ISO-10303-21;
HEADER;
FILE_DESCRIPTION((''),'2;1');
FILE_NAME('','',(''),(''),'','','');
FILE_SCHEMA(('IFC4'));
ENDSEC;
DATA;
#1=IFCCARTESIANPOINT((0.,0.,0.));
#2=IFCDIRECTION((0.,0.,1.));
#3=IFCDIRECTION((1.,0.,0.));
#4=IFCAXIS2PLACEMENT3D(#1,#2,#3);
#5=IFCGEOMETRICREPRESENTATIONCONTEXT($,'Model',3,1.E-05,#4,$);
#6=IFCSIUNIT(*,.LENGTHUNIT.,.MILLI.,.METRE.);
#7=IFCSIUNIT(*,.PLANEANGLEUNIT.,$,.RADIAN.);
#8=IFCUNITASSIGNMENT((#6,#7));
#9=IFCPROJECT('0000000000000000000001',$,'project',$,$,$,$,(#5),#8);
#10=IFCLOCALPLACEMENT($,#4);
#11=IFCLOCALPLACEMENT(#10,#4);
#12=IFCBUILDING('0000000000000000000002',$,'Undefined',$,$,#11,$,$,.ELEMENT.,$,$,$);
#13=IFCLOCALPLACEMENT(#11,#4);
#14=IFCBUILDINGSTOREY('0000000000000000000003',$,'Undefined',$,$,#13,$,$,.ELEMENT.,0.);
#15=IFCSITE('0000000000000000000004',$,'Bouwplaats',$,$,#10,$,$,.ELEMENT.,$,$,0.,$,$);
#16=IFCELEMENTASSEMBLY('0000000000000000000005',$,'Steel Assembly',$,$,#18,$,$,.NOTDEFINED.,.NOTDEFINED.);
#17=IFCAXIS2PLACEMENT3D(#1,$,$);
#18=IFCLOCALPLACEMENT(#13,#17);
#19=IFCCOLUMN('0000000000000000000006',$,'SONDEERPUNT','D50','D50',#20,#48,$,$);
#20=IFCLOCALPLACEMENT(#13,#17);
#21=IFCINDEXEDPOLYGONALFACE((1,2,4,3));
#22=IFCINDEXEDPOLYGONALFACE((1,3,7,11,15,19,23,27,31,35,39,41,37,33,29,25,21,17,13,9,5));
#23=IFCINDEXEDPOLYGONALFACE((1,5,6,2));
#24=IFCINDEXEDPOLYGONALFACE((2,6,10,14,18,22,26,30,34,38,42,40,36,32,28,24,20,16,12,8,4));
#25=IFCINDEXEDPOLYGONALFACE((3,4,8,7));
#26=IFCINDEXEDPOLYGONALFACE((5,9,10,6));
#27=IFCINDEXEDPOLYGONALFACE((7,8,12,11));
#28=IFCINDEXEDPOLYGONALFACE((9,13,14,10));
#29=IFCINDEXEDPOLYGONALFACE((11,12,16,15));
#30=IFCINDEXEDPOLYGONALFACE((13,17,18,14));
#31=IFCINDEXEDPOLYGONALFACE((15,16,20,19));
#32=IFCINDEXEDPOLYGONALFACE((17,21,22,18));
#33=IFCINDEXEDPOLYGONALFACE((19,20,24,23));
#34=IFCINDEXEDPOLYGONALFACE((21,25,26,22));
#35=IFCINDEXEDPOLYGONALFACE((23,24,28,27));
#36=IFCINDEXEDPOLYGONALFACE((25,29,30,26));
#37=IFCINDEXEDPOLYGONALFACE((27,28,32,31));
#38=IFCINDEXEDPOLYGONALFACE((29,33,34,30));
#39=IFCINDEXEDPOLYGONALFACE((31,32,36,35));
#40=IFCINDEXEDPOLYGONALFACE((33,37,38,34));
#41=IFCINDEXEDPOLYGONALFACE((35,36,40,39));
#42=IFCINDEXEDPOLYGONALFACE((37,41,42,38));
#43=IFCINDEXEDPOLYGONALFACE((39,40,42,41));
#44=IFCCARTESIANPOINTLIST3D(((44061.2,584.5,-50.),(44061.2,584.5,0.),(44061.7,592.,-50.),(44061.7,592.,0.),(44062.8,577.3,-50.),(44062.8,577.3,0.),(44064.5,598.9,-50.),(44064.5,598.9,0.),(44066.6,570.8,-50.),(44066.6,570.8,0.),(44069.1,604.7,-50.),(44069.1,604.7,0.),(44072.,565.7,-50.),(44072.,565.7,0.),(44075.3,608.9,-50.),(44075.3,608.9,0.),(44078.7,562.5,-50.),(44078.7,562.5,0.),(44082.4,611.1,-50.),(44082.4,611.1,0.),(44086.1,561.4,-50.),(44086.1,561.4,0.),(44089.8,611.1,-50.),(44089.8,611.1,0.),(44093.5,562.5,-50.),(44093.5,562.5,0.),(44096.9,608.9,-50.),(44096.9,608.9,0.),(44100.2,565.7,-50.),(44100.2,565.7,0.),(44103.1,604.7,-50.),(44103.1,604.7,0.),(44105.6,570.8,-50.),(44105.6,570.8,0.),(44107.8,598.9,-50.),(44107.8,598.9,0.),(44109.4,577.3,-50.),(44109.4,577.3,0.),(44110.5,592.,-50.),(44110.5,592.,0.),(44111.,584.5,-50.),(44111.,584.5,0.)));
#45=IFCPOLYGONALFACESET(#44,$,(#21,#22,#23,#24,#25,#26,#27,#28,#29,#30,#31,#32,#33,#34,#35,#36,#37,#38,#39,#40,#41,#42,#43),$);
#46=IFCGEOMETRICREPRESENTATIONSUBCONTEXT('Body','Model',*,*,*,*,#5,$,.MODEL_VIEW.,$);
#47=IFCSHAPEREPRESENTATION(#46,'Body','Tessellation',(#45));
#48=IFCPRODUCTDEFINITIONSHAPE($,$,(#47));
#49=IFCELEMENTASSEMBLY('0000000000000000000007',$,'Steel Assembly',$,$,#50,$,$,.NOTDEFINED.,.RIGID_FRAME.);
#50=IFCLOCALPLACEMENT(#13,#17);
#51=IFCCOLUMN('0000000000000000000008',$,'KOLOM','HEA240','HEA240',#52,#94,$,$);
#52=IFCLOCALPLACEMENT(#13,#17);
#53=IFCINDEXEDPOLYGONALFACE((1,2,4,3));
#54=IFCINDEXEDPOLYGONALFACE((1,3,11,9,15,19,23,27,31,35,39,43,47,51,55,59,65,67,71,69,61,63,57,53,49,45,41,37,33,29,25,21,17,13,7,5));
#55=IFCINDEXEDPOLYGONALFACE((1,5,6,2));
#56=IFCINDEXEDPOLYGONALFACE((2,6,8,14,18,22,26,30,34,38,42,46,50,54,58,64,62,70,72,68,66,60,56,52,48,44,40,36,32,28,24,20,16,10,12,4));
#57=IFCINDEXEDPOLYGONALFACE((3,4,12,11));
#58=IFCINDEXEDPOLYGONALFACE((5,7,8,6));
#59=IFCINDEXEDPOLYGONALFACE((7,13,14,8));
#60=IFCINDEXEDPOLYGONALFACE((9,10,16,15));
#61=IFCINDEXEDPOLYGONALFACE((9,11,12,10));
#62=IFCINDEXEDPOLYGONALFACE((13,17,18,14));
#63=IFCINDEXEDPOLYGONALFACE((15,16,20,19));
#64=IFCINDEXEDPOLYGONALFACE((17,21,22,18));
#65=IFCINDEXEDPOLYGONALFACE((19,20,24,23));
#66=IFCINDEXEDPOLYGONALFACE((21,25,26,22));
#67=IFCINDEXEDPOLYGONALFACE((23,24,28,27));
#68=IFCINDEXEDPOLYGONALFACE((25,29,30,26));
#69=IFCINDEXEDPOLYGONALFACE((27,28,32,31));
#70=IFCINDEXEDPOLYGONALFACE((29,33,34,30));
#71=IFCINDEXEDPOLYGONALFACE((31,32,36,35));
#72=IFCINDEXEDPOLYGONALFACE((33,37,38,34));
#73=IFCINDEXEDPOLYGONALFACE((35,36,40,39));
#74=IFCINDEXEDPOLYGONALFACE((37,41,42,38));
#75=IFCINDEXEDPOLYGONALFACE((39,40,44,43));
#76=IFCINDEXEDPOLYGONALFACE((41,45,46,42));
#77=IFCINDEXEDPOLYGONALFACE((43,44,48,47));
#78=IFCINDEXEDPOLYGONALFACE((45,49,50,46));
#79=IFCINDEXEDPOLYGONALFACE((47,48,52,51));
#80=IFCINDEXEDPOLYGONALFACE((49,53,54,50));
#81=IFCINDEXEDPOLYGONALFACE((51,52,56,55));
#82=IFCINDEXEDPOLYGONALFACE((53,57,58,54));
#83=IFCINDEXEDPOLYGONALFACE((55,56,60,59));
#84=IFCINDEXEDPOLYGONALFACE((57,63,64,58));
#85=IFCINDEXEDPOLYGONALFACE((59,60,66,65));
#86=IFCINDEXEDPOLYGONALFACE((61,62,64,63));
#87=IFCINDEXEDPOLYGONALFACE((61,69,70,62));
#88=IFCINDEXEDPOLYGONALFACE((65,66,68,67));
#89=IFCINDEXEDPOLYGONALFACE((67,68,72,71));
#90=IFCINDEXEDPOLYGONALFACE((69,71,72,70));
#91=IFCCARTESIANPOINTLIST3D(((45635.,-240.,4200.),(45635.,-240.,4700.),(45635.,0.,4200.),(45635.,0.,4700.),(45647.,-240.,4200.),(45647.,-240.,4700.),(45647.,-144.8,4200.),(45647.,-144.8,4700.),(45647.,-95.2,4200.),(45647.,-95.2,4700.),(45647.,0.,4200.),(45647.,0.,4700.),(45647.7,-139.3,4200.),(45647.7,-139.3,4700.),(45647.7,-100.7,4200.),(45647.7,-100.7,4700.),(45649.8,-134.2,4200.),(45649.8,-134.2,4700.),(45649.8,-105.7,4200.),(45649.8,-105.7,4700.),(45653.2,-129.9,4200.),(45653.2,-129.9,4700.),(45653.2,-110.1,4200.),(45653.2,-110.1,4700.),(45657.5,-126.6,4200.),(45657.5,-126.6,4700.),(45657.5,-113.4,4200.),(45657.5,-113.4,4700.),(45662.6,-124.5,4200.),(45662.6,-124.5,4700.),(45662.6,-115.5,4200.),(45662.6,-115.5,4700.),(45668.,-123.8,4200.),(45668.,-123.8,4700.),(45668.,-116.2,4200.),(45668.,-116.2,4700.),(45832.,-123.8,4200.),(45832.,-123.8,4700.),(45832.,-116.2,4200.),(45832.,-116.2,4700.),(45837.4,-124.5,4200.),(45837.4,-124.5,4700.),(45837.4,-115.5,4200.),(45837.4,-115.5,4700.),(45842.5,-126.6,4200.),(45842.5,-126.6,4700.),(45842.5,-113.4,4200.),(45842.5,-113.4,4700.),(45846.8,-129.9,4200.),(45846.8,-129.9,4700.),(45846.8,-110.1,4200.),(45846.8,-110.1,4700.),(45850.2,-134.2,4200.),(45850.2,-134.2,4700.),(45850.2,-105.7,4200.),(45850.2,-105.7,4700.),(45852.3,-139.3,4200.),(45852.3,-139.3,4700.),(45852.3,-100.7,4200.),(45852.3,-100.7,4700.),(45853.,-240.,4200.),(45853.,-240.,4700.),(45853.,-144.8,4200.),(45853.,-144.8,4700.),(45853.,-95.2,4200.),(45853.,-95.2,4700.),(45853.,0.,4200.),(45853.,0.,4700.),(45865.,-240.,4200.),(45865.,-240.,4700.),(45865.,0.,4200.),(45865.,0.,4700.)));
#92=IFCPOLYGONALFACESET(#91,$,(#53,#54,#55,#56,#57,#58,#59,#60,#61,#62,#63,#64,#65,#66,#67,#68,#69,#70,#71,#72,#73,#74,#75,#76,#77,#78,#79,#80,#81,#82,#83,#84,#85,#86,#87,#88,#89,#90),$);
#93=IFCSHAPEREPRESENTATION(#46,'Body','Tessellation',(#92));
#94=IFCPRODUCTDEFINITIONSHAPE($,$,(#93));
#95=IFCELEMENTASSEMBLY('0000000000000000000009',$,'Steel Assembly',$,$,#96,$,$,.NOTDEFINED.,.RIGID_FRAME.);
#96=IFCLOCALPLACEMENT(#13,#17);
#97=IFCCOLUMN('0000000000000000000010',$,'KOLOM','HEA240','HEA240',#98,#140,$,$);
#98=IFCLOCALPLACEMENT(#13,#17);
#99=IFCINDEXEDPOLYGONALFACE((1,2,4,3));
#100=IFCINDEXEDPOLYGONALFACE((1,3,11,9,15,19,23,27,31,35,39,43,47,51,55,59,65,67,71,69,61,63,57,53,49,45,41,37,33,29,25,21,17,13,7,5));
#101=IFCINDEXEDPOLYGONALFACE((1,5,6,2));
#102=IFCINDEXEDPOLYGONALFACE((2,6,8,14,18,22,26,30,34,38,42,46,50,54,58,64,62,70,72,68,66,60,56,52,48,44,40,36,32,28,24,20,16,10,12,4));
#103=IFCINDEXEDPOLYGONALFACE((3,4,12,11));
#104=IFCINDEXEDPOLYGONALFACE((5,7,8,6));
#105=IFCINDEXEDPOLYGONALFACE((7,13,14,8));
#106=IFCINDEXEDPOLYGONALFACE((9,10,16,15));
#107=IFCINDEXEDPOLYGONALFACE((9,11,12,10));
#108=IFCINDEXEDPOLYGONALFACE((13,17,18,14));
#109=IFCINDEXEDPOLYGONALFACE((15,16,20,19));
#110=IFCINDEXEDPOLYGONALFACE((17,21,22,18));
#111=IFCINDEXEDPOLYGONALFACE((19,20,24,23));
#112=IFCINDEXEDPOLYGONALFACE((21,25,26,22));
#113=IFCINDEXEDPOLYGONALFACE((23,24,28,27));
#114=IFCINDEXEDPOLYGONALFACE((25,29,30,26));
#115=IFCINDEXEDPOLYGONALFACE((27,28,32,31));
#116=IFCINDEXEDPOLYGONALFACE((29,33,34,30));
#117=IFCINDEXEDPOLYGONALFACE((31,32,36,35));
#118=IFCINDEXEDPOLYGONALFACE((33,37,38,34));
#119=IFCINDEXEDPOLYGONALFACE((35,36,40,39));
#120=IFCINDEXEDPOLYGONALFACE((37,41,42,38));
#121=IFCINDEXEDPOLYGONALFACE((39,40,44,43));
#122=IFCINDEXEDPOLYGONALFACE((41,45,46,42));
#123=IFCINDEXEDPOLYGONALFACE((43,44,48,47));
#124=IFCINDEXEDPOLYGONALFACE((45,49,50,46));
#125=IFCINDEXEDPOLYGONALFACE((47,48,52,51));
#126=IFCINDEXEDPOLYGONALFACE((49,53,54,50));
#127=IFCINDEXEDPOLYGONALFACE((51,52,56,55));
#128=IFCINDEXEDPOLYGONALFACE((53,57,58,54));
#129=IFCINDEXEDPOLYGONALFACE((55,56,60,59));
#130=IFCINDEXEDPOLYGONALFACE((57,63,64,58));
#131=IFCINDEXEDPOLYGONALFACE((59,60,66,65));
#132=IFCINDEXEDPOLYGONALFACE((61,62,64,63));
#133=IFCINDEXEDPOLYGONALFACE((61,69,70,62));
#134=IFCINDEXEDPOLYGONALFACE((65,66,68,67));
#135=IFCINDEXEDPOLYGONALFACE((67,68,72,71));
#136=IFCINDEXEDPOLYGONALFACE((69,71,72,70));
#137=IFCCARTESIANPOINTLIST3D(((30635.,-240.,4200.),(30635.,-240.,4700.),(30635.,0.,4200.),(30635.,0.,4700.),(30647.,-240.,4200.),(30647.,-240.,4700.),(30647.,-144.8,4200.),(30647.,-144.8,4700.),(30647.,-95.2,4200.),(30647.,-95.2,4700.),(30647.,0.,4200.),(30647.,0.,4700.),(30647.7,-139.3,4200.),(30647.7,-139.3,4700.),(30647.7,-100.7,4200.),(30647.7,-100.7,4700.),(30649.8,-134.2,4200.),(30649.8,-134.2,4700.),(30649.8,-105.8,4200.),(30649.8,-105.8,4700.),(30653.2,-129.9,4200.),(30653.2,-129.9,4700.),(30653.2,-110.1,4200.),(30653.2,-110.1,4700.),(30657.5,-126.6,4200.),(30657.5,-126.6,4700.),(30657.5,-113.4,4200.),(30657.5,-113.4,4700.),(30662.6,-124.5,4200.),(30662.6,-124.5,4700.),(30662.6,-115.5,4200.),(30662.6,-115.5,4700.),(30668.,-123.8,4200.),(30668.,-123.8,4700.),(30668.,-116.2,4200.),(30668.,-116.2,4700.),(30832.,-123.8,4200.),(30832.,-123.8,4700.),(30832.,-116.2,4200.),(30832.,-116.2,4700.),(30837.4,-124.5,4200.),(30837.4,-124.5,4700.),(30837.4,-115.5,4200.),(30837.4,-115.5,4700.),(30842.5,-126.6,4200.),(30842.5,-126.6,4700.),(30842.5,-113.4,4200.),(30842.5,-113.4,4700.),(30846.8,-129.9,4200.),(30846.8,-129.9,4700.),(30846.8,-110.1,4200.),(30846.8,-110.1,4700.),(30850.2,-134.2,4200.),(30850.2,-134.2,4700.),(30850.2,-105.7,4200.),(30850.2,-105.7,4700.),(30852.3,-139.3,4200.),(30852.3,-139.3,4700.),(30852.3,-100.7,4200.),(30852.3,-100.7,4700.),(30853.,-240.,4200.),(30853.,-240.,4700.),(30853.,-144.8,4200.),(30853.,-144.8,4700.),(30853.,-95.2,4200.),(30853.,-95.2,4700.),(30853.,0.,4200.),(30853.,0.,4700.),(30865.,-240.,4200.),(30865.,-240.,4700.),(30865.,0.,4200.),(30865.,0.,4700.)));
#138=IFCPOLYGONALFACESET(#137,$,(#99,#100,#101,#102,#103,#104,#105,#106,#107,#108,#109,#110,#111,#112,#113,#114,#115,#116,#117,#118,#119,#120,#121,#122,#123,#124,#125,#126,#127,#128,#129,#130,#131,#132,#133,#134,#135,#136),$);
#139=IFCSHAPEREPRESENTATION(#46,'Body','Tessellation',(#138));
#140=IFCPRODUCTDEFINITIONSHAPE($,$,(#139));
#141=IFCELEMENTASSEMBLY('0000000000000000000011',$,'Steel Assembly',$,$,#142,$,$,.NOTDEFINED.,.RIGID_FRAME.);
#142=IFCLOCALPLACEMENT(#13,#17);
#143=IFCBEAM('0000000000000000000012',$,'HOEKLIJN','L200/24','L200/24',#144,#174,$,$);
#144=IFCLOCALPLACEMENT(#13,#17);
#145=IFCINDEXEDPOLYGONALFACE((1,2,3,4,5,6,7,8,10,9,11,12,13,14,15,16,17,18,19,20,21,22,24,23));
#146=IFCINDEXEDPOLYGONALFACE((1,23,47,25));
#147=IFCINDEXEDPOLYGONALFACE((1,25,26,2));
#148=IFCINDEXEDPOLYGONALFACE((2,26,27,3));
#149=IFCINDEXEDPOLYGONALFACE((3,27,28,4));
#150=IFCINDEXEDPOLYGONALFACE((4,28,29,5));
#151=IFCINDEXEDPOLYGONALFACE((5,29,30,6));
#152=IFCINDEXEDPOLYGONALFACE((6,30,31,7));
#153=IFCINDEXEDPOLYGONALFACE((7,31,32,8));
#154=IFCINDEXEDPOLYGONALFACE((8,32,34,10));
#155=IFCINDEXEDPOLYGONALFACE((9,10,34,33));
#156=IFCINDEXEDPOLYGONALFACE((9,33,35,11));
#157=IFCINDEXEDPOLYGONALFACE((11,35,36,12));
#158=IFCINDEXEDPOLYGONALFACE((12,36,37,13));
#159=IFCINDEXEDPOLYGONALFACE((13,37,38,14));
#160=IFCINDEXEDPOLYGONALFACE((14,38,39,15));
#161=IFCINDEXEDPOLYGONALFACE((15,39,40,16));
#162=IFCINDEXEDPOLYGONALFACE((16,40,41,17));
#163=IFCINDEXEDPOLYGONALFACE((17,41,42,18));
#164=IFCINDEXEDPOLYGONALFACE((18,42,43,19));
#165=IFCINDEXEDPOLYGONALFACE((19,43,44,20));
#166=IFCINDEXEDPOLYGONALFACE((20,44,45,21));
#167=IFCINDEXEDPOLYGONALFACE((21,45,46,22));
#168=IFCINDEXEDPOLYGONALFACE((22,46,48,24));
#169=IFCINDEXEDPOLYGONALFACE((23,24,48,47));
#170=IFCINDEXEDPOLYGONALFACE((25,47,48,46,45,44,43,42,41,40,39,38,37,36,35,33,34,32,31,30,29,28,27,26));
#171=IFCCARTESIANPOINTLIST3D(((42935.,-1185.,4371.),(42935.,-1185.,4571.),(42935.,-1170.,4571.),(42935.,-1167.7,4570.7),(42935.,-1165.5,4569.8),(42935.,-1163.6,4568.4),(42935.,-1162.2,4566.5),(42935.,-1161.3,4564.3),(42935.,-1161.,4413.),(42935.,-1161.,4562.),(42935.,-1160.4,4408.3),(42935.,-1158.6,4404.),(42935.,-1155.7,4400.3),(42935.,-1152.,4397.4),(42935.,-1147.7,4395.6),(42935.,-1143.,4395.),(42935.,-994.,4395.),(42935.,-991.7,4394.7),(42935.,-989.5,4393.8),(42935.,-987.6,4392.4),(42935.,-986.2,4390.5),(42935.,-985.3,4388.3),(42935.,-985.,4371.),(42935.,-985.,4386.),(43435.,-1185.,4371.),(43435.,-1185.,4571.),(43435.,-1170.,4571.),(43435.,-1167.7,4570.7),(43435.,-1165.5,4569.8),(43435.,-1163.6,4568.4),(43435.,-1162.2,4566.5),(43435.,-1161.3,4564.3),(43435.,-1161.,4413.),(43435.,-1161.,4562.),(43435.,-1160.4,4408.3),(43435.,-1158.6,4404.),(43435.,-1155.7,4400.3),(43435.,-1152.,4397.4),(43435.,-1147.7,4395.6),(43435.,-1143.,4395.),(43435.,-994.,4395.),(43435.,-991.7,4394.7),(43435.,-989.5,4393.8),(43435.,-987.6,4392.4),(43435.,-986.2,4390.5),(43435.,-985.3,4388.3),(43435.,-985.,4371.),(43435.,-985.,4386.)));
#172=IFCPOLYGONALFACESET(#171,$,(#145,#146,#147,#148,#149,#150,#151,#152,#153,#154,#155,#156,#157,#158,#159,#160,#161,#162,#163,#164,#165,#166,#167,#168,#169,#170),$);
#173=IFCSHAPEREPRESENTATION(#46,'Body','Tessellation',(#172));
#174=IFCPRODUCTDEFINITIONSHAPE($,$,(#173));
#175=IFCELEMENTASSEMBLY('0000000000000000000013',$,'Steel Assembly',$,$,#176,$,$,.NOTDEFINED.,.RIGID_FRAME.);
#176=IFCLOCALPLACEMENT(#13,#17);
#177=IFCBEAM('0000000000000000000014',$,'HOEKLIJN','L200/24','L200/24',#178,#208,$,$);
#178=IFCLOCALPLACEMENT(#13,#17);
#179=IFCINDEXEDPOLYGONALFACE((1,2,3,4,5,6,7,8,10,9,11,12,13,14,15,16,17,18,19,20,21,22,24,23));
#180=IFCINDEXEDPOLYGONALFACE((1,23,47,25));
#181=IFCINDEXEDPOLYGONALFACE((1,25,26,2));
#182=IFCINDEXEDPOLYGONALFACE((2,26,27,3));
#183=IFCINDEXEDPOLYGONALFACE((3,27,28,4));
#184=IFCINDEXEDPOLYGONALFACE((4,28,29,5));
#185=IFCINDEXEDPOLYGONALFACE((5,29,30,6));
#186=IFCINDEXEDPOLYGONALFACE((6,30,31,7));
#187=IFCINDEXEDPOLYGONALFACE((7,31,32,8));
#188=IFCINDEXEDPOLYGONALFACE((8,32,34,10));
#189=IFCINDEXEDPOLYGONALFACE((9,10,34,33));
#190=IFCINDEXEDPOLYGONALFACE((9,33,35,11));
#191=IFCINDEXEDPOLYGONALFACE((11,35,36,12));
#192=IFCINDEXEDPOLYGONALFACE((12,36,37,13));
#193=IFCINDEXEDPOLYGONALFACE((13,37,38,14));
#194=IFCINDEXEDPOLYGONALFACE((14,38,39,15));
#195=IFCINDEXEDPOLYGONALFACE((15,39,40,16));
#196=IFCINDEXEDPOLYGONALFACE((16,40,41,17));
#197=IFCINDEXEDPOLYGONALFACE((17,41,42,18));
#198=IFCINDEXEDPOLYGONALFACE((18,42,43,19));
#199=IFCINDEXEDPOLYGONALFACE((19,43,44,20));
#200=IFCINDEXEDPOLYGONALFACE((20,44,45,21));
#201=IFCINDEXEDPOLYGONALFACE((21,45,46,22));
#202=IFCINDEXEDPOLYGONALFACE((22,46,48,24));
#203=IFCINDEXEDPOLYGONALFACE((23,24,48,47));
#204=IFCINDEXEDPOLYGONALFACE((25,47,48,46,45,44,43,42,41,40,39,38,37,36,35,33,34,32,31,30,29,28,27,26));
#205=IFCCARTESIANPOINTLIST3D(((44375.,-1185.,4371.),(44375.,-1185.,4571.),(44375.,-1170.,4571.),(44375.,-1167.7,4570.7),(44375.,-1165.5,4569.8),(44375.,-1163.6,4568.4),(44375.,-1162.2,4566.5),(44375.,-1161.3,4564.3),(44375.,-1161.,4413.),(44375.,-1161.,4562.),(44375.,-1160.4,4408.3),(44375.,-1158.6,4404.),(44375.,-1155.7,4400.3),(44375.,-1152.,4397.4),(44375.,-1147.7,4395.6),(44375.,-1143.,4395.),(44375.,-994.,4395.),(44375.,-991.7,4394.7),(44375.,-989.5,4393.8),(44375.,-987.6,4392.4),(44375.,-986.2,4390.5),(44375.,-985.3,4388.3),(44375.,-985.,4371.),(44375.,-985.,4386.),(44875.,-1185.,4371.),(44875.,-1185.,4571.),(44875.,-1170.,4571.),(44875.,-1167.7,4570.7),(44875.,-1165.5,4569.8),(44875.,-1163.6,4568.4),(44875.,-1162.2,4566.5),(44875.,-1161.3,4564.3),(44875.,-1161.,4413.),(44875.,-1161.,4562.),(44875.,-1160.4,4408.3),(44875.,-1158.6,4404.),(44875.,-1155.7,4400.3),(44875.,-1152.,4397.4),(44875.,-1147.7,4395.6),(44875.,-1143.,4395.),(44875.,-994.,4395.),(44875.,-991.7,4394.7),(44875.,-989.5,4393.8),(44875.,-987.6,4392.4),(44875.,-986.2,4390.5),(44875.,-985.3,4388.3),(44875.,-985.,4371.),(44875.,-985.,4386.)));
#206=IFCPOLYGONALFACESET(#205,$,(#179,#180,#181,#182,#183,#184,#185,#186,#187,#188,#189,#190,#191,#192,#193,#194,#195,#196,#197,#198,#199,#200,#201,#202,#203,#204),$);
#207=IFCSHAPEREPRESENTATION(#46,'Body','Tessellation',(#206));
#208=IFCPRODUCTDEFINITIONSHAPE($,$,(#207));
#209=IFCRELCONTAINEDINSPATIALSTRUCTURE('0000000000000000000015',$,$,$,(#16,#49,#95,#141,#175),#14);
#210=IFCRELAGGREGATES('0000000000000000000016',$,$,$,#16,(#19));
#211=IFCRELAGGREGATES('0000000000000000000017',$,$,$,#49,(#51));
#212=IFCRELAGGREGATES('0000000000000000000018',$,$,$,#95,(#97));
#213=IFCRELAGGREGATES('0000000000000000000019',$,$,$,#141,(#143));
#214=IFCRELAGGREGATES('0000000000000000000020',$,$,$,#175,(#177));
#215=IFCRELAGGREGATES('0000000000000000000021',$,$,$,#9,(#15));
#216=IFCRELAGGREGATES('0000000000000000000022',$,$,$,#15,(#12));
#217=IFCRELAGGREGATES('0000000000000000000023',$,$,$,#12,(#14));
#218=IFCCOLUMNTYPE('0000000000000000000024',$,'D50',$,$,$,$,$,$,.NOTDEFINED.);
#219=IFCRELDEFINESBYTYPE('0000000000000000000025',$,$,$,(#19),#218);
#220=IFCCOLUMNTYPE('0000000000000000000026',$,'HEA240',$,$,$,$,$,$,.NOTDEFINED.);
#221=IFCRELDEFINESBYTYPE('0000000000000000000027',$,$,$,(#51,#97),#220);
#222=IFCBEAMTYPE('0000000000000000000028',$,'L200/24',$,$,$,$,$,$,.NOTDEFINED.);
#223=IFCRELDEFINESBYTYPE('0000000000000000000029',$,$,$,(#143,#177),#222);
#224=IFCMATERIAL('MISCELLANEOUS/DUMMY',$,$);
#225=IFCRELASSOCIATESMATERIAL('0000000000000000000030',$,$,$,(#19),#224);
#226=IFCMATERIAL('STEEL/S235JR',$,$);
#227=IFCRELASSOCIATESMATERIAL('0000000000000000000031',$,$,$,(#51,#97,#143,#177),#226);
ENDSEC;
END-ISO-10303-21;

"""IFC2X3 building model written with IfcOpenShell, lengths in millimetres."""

from ifc_helpers import new_model, si_unit, frame, origin_with_axes, origin_2d_with_axis, place, context, subcontext, project, spatial, circle, i_section, l_section, extrude, material, type_object, element, aggregate, save


model = new_model("IFC2X3")

# Units and contexts
model_context = context("Model", 3, precision=1e-05, world=origin_with_axes())
body_context = subcontext(model_context, "Body", "Model", "MODEL_VIEW")
ifc_project = project(units=[si_unit("LENGTHUNIT", "METRE", prefix="MILLI"), si_unit("PLANEANGLEUNIT", "RADIAN")], contexts=[model_context])

# Site, building, storey
site_placement = place(None, origin_with_axes())
site = spatial("IfcSite", under=ifc_project, at=site_placement, Name="Bouwplaats", CompositionType="ELEMENT", RefElevation=0.0)
building_placement = place(site_placement, origin_with_axes())
building = spatial("IfcBuilding", under=site, at=building_placement, Name="Undefined", CompositionType="ELEMENT")
storey_placement = place(building_placement, origin_with_axes())
storey = spatial("IfcBuildingStorey", under=building, at=storey_placement, Name="Undefined", CompositionType="ELEMENT", Elevation=0.0)

# Element assemblies, columns
assembly_1_placement = place(storey_placement, origin_with_axes())
assembly_1 = element("IfcElementAssembly", 1, at=assembly_1_placement, inside=storey, Name="Steel Assembly", AssemblyPlace="NOTDEFINED", PredefinedType="NOTDEFINED")
ifc_material_1 = material(Name="MISCELLANEOUS/DUMMY")
column_type_1 = type_object("IfcColumnType", Name="D50", PredefinedType="NOTDEFINED")
column_1_placement = place(assembly_1_placement, frame((44086.1, 586.4, -50.0), z_axis=(0.0, 0.0, 1.0), x_axis=(-1.0, 0.0, 0.0)))
column_1 = element("IfcColumn", 2, at=column_1_placement, type_object=column_type_1, material=ifc_material_1, Name="SONDEERPUNT", Description="D50", ObjectType="D50", context=body_context, shape_type="SweptSolid", body=[
    extrude(circle(Radius=25.0, at=origin_2d_with_axis()), frame((0.0, 0.0, 50.0), z_axis=(0.0, 0.0, -1.0), x_axis=(0.0, 1.0, 0.0)), (0.0, 0.0, 1.0), 50.0),
])
aggregate(assembly_1, [column_1])
assembly_2_placement = place(storey_placement, origin_with_axes())
assembly_2 = element("IfcElementAssembly", 3, at=assembly_2_placement, inside=storey, Name="Steel Assembly", AssemblyPlace="NOTDEFINED", PredefinedType="RIGID_FRAME")
ifc_material_2 = material(Name="STEEL/S235JR")
column_type_2 = type_object("IfcColumnType", Name="HEA240", PredefinedType="NOTDEFINED")
column_2_placement = place(assembly_2_placement, frame((45750.0, -120.0, 4200.0), z_axis=(0.0, 0.0, 1.0), x_axis=(1.0, 0.0, 0.0)))
column_2 = element("IfcColumn", 4, at=column_2_placement, type_object=column_type_2, material=ifc_material_2, Name="KOLOM", Description="HEA240", ObjectType="HEA240", context=body_context, shape_type="SweptSolid", body=[
    extrude(i_section(OverallWidth=240.0, OverallDepth=230.0, WebThickness=7.5, FlangeThickness=12.0, FilletRadius=21.0, at=origin_2d_with_axis()), frame((0.0, 0.0, 500.0), z_axis=(0.0, 0.0, -1.0), x_axis=(0.0, 1.0, 0.0)), (0.0, 0.0, 1.0), 500.0),
])
aggregate(assembly_2, [column_2])
assembly_3_placement = place(storey_placement, origin_with_axes())
assembly_3 = element("IfcElementAssembly", 5, at=assembly_3_placement, inside=storey, Name="Steel Assembly", AssemblyPlace="NOTDEFINED", PredefinedType="RIGID_FRAME")
column_3_placement = place(assembly_3_placement, frame((30750.0, -120.0, 4200.0), z_axis=(0.0, 0.0, 1.0), x_axis=(-1.0, 0.0, 0.0)))
column_3 = element("IfcColumn", 6, at=column_3_placement, type_object=column_type_2, material=ifc_material_2, Name="KOLOM", Description="HEA240", ObjectType="HEA240", context=body_context, shape_type="SweptSolid", body=[
    extrude(i_section(OverallWidth=240.0, OverallDepth=230.0, WebThickness=7.5, FlangeThickness=12.0, FilletRadius=21.0, at=origin_2d_with_axis()), frame((0.0, 0.0, 500.0), z_axis=(0.0, 0.0, -1.0), x_axis=(0.0, 1.0, 0.0)), (0.0, 0.0, 1.0), 500.0),
])
aggregate(assembly_3, [column_3])

# Element assemblies, beams
assembly_4_placement = place(storey_placement, origin_with_axes())
assembly_4 = element("IfcElementAssembly", 7, at=assembly_4_placement, inside=storey, Name="Steel Assembly", AssemblyPlace="NOTDEFINED", PredefinedType="RIGID_FRAME")
beam_type_1 = type_object("IfcBeamType", Name="L200/24", PredefinedType="NOTDEFINED")
beam_1_placement = place(assembly_4_placement, frame((42935.0, -1085.0, 4471.0), z_axis=(0.0, 1.0, 0.0), x_axis=(1.0, 0.0, 0.0)))
beam_1 = element("IfcBeam", 8, at=beam_1_placement, type_object=beam_type_1, material=ifc_material_2, Name="HOEKLIJN", Description="L200/24", ObjectType="L200/24", context=body_context, shape_type="SweptSolid", body=[
    extrude(l_section(Depth=200.0, Width=200.0, Thickness=24.0, FilletRadius=18.0, EdgeRadius=9.0, at=origin_2d_with_axis()), frame((500.0, 0.0, 0.0), z_axis=(-1.0, 0.0, 0.0), x_axis=(0.0, -1.0, 0.0)), (0.0, 0.0, 1.0), 500.0),
])
aggregate(assembly_4, [beam_1])
assembly_5_placement = place(storey_placement, origin_with_axes())
assembly_5 = element("IfcElementAssembly", 9, at=assembly_5_placement, inside=storey, Name="Steel Assembly", AssemblyPlace="NOTDEFINED", PredefinedType="RIGID_FRAME")
beam_2_placement = place(assembly_5_placement, frame((44375.0, -1085.0, 4471.0), z_axis=(0.0, 1.0, 0.0), x_axis=(1.0, 0.0, 0.0)))
beam_2 = element("IfcBeam", 10, at=beam_2_placement, type_object=beam_type_1, material=ifc_material_2, Name="HOEKLIJN", Description="L200/24", ObjectType="L200/24", context=body_context, shape_type="SweptSolid", body=[
    extrude(l_section(Depth=200.0, Width=200.0, Thickness=24.0, FilletRadius=18.0, EdgeRadius=9.0, at=origin_2d_with_axis()), frame((500.0, 0.0, 0.0), z_axis=(-1.0, 0.0, 0.0), x_axis=(0.0, -1.0, 0.0)), (0.0, 0.0, 1.0), 500.0),
])
aggregate(assembly_5, [beam_2])

save(model, "model.ifc")
